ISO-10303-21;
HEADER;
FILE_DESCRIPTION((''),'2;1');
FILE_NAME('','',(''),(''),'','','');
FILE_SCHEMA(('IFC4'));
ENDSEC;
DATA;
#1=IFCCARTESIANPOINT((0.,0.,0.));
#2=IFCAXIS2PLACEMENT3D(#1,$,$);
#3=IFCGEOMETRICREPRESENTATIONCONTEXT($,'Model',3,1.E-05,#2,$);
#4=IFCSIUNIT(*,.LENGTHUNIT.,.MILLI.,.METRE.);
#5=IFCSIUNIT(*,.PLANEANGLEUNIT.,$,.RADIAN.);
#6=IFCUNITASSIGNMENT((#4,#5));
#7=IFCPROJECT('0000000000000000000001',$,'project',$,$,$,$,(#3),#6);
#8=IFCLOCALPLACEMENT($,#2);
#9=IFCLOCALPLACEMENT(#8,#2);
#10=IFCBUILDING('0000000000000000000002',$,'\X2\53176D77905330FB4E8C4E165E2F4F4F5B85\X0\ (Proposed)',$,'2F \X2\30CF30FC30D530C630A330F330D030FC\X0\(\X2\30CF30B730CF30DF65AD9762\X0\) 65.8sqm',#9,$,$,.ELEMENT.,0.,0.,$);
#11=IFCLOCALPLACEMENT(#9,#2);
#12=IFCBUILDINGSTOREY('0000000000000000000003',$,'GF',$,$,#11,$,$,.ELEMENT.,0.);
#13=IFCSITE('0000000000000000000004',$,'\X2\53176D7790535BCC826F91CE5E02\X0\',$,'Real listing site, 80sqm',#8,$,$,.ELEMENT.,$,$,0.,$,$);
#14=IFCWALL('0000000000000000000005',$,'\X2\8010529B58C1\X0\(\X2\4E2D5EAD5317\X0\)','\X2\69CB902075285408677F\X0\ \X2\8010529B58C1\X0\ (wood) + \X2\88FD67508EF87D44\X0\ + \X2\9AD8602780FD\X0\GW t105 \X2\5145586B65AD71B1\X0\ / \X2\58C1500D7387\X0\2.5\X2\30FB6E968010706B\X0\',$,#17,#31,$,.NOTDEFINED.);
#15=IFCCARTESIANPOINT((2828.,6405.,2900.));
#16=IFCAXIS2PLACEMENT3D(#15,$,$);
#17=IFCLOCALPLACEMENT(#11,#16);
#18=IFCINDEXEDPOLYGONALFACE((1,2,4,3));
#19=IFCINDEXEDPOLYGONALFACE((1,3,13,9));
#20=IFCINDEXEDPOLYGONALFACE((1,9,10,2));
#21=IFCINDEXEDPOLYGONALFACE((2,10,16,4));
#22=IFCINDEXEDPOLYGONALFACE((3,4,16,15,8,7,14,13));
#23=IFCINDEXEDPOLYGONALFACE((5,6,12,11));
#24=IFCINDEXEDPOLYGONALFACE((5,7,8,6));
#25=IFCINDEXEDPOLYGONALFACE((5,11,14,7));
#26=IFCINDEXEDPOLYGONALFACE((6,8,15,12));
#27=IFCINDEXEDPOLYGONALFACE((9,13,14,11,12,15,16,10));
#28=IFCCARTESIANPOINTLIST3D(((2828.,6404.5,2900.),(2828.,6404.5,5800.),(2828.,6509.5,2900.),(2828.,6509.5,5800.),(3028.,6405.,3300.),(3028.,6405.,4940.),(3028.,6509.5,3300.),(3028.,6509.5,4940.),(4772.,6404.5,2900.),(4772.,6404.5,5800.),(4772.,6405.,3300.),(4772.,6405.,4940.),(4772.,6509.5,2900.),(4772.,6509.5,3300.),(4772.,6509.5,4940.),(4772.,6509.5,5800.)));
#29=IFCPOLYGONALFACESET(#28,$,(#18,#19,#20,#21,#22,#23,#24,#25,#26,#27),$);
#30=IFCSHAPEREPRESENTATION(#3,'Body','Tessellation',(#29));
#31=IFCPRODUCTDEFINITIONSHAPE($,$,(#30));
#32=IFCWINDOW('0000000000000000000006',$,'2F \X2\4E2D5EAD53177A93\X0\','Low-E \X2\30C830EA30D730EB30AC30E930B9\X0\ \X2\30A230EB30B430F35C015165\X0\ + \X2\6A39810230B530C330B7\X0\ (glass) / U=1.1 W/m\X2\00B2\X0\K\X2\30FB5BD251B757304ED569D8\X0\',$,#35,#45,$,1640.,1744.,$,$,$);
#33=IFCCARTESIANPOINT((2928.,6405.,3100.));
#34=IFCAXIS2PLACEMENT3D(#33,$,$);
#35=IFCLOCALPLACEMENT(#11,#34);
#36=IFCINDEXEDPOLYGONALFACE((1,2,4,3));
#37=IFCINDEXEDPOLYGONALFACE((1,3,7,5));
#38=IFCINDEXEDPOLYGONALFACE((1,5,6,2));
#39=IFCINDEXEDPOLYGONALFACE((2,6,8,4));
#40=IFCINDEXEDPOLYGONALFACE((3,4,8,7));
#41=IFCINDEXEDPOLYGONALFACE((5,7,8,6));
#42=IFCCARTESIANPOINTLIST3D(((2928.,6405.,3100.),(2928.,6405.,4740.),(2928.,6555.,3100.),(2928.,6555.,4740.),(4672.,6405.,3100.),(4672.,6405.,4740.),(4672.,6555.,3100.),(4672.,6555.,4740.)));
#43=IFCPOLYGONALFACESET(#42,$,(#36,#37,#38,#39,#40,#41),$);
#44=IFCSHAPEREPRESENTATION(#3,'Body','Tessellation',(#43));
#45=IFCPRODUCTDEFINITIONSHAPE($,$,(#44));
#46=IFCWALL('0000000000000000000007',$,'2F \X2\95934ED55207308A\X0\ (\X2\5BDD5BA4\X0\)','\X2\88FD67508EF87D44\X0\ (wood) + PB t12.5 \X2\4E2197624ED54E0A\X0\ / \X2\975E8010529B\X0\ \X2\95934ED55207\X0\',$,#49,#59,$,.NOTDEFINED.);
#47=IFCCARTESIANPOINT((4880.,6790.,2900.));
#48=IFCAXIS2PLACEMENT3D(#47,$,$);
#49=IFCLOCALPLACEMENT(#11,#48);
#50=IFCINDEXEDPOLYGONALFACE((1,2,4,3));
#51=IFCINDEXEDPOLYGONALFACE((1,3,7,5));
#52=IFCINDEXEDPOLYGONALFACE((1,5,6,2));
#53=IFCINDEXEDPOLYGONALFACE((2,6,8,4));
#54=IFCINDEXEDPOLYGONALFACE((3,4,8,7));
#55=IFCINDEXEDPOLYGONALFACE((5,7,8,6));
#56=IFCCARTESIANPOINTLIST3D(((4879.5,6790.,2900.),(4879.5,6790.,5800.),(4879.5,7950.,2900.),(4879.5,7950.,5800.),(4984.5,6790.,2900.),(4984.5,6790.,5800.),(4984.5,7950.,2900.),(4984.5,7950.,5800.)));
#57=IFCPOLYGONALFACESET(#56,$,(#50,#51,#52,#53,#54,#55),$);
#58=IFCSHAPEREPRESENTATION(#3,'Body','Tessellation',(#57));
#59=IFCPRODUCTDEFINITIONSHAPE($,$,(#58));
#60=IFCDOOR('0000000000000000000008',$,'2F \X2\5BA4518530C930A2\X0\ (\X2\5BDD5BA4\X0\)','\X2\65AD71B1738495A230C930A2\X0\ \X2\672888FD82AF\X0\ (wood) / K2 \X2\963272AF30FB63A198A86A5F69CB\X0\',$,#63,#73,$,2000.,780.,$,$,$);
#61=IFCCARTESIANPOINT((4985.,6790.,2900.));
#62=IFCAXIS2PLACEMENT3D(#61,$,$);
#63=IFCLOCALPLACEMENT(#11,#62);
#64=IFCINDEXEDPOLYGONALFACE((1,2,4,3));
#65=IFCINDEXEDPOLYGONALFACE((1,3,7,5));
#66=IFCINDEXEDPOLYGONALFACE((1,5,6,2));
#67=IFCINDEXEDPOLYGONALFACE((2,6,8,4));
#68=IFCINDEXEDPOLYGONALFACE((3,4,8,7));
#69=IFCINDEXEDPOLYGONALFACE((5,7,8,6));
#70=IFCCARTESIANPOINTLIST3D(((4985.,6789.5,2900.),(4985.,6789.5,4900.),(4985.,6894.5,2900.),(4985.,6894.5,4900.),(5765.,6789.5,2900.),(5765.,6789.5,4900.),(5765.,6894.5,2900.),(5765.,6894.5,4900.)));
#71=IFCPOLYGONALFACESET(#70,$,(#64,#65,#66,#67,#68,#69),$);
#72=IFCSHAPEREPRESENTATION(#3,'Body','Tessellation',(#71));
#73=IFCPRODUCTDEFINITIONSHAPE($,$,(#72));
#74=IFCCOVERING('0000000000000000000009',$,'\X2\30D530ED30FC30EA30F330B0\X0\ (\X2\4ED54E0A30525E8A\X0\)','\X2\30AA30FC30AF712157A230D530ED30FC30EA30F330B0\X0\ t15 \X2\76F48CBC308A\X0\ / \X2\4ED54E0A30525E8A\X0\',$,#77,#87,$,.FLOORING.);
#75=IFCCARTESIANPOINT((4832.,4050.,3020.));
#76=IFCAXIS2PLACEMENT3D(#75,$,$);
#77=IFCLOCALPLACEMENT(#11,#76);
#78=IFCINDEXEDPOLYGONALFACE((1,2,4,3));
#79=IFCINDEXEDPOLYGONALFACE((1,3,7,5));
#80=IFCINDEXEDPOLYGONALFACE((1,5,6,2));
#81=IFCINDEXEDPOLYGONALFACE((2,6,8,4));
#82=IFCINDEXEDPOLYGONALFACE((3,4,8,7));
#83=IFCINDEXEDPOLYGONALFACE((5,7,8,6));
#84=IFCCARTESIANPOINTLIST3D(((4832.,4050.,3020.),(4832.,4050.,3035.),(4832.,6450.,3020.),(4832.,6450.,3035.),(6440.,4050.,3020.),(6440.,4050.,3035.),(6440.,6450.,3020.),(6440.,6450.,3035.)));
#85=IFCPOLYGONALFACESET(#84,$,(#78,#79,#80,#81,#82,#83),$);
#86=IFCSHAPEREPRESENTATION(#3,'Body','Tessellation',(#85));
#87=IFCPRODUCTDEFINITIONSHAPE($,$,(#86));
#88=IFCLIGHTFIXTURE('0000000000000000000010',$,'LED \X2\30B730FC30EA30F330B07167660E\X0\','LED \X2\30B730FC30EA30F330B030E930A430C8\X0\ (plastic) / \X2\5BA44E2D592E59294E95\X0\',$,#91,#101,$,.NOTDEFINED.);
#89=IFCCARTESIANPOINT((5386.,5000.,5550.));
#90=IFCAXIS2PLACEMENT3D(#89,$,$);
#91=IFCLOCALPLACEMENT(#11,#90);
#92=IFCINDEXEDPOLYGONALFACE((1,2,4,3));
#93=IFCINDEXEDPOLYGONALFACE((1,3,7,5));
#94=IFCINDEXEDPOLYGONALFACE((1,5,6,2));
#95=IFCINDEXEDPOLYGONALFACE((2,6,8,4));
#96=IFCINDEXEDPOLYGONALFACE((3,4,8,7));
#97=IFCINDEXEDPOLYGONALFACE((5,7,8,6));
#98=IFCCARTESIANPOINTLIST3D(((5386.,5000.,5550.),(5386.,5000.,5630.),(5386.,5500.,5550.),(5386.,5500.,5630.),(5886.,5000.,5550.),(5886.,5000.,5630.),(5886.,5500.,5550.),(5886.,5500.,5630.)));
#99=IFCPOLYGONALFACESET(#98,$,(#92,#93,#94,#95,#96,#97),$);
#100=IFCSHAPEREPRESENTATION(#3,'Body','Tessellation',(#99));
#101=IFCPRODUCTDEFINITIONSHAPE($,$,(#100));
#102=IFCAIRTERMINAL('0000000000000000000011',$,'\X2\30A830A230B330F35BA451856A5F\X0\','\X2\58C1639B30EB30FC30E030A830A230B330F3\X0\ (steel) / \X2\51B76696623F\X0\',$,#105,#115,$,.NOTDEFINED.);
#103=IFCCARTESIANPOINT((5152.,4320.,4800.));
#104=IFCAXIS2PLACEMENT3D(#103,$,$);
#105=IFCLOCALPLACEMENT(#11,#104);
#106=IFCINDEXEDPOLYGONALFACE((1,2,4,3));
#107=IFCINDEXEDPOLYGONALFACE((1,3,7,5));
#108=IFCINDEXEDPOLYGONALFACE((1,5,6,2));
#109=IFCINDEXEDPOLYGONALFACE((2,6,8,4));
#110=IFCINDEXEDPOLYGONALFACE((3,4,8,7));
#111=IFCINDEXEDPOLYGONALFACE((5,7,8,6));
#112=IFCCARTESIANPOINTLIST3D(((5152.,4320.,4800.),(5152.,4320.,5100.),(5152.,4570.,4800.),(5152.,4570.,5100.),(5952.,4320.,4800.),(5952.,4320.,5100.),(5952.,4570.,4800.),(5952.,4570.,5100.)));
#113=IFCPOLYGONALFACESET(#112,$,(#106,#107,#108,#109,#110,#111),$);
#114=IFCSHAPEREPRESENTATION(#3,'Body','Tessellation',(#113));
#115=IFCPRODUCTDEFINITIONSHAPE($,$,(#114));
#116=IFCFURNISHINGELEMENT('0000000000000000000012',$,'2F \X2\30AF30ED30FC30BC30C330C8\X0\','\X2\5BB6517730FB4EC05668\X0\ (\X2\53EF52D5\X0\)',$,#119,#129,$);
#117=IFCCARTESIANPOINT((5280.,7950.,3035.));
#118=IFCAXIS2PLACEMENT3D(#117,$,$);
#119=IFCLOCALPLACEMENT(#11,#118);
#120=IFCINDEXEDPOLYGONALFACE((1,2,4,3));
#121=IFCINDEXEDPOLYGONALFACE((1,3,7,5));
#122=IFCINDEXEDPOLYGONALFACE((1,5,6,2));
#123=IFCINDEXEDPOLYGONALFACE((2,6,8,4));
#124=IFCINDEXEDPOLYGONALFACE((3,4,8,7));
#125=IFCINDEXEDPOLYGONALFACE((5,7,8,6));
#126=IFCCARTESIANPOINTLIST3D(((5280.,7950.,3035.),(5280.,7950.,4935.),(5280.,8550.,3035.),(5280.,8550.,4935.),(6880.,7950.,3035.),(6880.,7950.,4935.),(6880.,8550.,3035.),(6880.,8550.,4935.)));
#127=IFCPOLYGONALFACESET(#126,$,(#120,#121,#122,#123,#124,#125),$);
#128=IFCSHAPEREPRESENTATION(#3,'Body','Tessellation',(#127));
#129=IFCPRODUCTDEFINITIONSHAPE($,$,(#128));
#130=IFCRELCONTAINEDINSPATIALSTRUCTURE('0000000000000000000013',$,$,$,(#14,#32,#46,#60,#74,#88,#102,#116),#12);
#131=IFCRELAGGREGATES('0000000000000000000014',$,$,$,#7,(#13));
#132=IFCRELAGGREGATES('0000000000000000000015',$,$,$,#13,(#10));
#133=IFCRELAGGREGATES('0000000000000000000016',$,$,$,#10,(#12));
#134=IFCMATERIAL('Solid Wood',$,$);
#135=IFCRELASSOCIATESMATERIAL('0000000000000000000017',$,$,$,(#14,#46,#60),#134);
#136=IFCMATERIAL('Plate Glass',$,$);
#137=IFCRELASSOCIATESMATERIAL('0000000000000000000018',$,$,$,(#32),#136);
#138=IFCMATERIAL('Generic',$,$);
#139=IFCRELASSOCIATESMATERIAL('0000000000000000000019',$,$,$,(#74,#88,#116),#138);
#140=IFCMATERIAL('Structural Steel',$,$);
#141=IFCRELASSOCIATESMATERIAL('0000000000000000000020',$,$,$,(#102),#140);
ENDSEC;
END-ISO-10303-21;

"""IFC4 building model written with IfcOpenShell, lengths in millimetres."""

from ifc_helpers import new_model, si_unit, frame, frame_2d, origin, place, context, project, spatial, rectangle, extrude, material, element, fill, save


model = new_model("IFC4")

# Units and contexts
model_context = context("Model", 3, precision=1e-05, world=origin())
ifc_project = project(units=[si_unit("LENGTHUNIT", "METRE", prefix="MILLI"), si_unit("PLANEANGLEUNIT", "RADIAN")], contexts=[model_context])

# Site, building, storey
site_placement = place(None, origin())
site = spatial("IfcSite", under=ifc_project, at=site_placement, Name="北海道富良野市", ObjectType="Real listing site, 80sqm", CompositionType="ELEMENT", RefElevation=0.0)
building_placement = place(site_placement, origin())
building = spatial("IfcBuilding", under=site, at=building_placement, Name="北海道・二世帯住宅 (Proposed)", ObjectType="2F ハーフティンバー(ハシハミ断面) 65.8sqm", CompositionType="ELEMENT", ElevationOfRefHeight=0.0, ElevationOfTerrain=0.0)
storey_placement = place(building_placement, origin())
storey = spatial("IfcBuildingStorey", under=building, at=storey_placement, Name="GF", CompositionType="ELEMENT", Elevation=0.0)

# Shared definitions
ifc_material_1 = material(Name="Solid Wood")

# Wall, opening, window
wall_1_placement = place(storey_placement, frame((2828.0, 6405.0, 2900.0)))
wall_1 = element("IfcWall", 1, at=wall_1_placement, inside=storey, material=ifc_material_1, Name="耐力壁(中庭北)", Description="構造用合板 耐力壁 (wood) + 製材軸組 + 高性能GW t105 充填断熱 / 壁倍率2.5・準耐火", PredefinedType="NOTDEFINED", context=model_context, shape_type="SweptSolid", body=[
    extrude(rectangle(XDim=1944.0, YDim=105.0, at=frame_2d((972.0, 52.0))), frame((2828.0, 6405.0, 2900.0)), (0.0, 0.0, 1.0), 2900.0),
])
opening_placement = place(storey_placement, frame((2928.0, 6405.0, 3100.0)))
opening = element("IfcOpeningElement", 2, at=opening_placement, cuts=wall_1, PredefinedType="NOTDEFINED", context=model_context, shape_type="SweptSolid", body=[
    extrude(rectangle(XDim=1744.0, YDim=150.0, at=frame_2d((872.0, 75.0))), frame((2928.0, 6405.0, 3100.0)), (0.0, 0.0, 1.0), 1640.0),
])
ifc_material_2 = material(Name="Plate Glass")
window_placement = place(storey_placement, frame((2928.0, 6405.0, 3100.0)))
window = element("IfcWindow", 3, at=window_placement, inside=storey, material=ifc_material_2, Name="2F 中庭北窓", Description="Low-E トリプルガラス アルゴン封入 + 樹脂サッシ (glass) / U=1.1 W/m²K・寒冷地仕様", OverallHeight=1640.0, OverallWidth=1744.0, context=model_context, shape_type="SweptSolid", body=[
    extrude(rectangle(XDim=1744.0, YDim=150.0, at=frame_2d((872.0, 75.0))), frame((2928.0, 6405.0, 3100.0)), (0.0, 0.0, 1.0), 1640.0),
])
fill(opening, window)

# Wall
wall_2_placement = place(storey_placement, frame((4880.0, 6790.0, 2900.0)))
element("IfcWall", 4, at=wall_2_placement, inside=storey, material=ifc_material_1, Name="2F 間仕切り (寝室)", Description="製材軸組 (wood) + PB t12.5 両面仕上 / 非耐力 間仕切", PredefinedType="NOTDEFINED", context=model_context, shape_type="SweptSolid", body=[
    extrude(rectangle(XDim=105.0, YDim=1160.0, at=frame_2d((52.0, 580.0))), frame((4880.0, 6790.0, 2900.0)), (0.0, 0.0, 1.0), 2900.0),
])

# Door
door_placement = place(storey_placement, frame((4985.0, 6790.0, 2900.0)))
element("IfcDoor", 5, at=door_placement, inside=storey, material=ifc_material_1, Name="2F 室内ドア (寝室)", Description="断熱玄関ドア 木製芯 (wood) / K2 防犯・採風機構", OverallHeight=2000.0, OverallWidth=780.0, context=model_context, shape_type="SweptSolid", body=[
    extrude(rectangle(XDim=780.0, YDim=105.0, at=frame_2d((390.0, 52.0))), frame((4985.0, 6790.0, 2900.0)), (0.0, 0.0, 1.0), 2000.0),
])

# Covering
ifc_material_3 = material(Name="Generic")
covering_placement = place(storey_placement, frame((4832.0, 4050.0, 3020.0)))
element("IfcCovering", 6, at=covering_placement, inside=storey, material=ifc_material_3, Name="フローリング (仕上げ床)", Description="オーク無垢フローリング t15 直貼り / 仕上げ床", PredefinedType="FLOORING", context=model_context, shape_type="SweptSolid", body=[
    extrude(rectangle(XDim=1608.0, YDim=2400.0, at=frame_2d((804.0, 1200.0))), frame((4832.0, 4050.0, 3020.0)), (0.0, 0.0, 1.0), 15.0),
])

# Light fixture
light_fixture_placement = place(storey_placement, frame((5386.0, 5000.0, 5550.0)))
element("IfcLightFixture", 7, at=light_fixture_placement, inside=storey, material=ifc_material_3, Name="LED シーリング照明", Description="LED シーリングライト (plastic) / 室中央天井", PredefinedType="NOTDEFINED", context=model_context, shape_type="SweptSolid", body=[
    extrude(rectangle(XDim=500.0, YDim=500.0, at=frame_2d((250.0, 250.0))), frame((5386.0, 5000.0, 5550.0)), (0.0, 0.0, 1.0), 80.0),
])

# Air terminal
ifc_material_4 = material(Name="Structural Steel")
air_terminal_placement = place(storey_placement, frame((5152.0, 4320.0, 4800.0)))
element("IfcAirTerminal", 8, at=air_terminal_placement, inside=storey, material=ifc_material_4, Name="エアコン室内機", Description="壁掛ルームエアコン (steel) / 冷暖房", PredefinedType="NOTDEFINED", context=model_context, shape_type="SweptSolid", body=[
    extrude(rectangle(XDim=800.0, YDim=250.0, at=frame_2d((400.0, 125.0))), frame((5152.0, 4320.0, 4800.0)), (0.0, 0.0, 1.0), 300.0),
])

# Furnishing element
furnishing_placement = place(storey_placement, frame((5280.0, 7950.0, 3035.0)))
element("IfcFurnishingElement", 9, at=furnishing_placement, inside=storey, material=ifc_material_3, Name="2F クローゼット", Description="家具・什器 (可動)", context=model_context, shape_type="SweptSolid", body=[
    extrude(rectangle(XDim=1600.0, YDim=600.0, at=frame_2d((800.0, 300.0))), frame((5280.0, 7950.0, 3035.0)), (0.0, 0.0, 1.0), 1900.0),
])

save(model, "model.ifc")
